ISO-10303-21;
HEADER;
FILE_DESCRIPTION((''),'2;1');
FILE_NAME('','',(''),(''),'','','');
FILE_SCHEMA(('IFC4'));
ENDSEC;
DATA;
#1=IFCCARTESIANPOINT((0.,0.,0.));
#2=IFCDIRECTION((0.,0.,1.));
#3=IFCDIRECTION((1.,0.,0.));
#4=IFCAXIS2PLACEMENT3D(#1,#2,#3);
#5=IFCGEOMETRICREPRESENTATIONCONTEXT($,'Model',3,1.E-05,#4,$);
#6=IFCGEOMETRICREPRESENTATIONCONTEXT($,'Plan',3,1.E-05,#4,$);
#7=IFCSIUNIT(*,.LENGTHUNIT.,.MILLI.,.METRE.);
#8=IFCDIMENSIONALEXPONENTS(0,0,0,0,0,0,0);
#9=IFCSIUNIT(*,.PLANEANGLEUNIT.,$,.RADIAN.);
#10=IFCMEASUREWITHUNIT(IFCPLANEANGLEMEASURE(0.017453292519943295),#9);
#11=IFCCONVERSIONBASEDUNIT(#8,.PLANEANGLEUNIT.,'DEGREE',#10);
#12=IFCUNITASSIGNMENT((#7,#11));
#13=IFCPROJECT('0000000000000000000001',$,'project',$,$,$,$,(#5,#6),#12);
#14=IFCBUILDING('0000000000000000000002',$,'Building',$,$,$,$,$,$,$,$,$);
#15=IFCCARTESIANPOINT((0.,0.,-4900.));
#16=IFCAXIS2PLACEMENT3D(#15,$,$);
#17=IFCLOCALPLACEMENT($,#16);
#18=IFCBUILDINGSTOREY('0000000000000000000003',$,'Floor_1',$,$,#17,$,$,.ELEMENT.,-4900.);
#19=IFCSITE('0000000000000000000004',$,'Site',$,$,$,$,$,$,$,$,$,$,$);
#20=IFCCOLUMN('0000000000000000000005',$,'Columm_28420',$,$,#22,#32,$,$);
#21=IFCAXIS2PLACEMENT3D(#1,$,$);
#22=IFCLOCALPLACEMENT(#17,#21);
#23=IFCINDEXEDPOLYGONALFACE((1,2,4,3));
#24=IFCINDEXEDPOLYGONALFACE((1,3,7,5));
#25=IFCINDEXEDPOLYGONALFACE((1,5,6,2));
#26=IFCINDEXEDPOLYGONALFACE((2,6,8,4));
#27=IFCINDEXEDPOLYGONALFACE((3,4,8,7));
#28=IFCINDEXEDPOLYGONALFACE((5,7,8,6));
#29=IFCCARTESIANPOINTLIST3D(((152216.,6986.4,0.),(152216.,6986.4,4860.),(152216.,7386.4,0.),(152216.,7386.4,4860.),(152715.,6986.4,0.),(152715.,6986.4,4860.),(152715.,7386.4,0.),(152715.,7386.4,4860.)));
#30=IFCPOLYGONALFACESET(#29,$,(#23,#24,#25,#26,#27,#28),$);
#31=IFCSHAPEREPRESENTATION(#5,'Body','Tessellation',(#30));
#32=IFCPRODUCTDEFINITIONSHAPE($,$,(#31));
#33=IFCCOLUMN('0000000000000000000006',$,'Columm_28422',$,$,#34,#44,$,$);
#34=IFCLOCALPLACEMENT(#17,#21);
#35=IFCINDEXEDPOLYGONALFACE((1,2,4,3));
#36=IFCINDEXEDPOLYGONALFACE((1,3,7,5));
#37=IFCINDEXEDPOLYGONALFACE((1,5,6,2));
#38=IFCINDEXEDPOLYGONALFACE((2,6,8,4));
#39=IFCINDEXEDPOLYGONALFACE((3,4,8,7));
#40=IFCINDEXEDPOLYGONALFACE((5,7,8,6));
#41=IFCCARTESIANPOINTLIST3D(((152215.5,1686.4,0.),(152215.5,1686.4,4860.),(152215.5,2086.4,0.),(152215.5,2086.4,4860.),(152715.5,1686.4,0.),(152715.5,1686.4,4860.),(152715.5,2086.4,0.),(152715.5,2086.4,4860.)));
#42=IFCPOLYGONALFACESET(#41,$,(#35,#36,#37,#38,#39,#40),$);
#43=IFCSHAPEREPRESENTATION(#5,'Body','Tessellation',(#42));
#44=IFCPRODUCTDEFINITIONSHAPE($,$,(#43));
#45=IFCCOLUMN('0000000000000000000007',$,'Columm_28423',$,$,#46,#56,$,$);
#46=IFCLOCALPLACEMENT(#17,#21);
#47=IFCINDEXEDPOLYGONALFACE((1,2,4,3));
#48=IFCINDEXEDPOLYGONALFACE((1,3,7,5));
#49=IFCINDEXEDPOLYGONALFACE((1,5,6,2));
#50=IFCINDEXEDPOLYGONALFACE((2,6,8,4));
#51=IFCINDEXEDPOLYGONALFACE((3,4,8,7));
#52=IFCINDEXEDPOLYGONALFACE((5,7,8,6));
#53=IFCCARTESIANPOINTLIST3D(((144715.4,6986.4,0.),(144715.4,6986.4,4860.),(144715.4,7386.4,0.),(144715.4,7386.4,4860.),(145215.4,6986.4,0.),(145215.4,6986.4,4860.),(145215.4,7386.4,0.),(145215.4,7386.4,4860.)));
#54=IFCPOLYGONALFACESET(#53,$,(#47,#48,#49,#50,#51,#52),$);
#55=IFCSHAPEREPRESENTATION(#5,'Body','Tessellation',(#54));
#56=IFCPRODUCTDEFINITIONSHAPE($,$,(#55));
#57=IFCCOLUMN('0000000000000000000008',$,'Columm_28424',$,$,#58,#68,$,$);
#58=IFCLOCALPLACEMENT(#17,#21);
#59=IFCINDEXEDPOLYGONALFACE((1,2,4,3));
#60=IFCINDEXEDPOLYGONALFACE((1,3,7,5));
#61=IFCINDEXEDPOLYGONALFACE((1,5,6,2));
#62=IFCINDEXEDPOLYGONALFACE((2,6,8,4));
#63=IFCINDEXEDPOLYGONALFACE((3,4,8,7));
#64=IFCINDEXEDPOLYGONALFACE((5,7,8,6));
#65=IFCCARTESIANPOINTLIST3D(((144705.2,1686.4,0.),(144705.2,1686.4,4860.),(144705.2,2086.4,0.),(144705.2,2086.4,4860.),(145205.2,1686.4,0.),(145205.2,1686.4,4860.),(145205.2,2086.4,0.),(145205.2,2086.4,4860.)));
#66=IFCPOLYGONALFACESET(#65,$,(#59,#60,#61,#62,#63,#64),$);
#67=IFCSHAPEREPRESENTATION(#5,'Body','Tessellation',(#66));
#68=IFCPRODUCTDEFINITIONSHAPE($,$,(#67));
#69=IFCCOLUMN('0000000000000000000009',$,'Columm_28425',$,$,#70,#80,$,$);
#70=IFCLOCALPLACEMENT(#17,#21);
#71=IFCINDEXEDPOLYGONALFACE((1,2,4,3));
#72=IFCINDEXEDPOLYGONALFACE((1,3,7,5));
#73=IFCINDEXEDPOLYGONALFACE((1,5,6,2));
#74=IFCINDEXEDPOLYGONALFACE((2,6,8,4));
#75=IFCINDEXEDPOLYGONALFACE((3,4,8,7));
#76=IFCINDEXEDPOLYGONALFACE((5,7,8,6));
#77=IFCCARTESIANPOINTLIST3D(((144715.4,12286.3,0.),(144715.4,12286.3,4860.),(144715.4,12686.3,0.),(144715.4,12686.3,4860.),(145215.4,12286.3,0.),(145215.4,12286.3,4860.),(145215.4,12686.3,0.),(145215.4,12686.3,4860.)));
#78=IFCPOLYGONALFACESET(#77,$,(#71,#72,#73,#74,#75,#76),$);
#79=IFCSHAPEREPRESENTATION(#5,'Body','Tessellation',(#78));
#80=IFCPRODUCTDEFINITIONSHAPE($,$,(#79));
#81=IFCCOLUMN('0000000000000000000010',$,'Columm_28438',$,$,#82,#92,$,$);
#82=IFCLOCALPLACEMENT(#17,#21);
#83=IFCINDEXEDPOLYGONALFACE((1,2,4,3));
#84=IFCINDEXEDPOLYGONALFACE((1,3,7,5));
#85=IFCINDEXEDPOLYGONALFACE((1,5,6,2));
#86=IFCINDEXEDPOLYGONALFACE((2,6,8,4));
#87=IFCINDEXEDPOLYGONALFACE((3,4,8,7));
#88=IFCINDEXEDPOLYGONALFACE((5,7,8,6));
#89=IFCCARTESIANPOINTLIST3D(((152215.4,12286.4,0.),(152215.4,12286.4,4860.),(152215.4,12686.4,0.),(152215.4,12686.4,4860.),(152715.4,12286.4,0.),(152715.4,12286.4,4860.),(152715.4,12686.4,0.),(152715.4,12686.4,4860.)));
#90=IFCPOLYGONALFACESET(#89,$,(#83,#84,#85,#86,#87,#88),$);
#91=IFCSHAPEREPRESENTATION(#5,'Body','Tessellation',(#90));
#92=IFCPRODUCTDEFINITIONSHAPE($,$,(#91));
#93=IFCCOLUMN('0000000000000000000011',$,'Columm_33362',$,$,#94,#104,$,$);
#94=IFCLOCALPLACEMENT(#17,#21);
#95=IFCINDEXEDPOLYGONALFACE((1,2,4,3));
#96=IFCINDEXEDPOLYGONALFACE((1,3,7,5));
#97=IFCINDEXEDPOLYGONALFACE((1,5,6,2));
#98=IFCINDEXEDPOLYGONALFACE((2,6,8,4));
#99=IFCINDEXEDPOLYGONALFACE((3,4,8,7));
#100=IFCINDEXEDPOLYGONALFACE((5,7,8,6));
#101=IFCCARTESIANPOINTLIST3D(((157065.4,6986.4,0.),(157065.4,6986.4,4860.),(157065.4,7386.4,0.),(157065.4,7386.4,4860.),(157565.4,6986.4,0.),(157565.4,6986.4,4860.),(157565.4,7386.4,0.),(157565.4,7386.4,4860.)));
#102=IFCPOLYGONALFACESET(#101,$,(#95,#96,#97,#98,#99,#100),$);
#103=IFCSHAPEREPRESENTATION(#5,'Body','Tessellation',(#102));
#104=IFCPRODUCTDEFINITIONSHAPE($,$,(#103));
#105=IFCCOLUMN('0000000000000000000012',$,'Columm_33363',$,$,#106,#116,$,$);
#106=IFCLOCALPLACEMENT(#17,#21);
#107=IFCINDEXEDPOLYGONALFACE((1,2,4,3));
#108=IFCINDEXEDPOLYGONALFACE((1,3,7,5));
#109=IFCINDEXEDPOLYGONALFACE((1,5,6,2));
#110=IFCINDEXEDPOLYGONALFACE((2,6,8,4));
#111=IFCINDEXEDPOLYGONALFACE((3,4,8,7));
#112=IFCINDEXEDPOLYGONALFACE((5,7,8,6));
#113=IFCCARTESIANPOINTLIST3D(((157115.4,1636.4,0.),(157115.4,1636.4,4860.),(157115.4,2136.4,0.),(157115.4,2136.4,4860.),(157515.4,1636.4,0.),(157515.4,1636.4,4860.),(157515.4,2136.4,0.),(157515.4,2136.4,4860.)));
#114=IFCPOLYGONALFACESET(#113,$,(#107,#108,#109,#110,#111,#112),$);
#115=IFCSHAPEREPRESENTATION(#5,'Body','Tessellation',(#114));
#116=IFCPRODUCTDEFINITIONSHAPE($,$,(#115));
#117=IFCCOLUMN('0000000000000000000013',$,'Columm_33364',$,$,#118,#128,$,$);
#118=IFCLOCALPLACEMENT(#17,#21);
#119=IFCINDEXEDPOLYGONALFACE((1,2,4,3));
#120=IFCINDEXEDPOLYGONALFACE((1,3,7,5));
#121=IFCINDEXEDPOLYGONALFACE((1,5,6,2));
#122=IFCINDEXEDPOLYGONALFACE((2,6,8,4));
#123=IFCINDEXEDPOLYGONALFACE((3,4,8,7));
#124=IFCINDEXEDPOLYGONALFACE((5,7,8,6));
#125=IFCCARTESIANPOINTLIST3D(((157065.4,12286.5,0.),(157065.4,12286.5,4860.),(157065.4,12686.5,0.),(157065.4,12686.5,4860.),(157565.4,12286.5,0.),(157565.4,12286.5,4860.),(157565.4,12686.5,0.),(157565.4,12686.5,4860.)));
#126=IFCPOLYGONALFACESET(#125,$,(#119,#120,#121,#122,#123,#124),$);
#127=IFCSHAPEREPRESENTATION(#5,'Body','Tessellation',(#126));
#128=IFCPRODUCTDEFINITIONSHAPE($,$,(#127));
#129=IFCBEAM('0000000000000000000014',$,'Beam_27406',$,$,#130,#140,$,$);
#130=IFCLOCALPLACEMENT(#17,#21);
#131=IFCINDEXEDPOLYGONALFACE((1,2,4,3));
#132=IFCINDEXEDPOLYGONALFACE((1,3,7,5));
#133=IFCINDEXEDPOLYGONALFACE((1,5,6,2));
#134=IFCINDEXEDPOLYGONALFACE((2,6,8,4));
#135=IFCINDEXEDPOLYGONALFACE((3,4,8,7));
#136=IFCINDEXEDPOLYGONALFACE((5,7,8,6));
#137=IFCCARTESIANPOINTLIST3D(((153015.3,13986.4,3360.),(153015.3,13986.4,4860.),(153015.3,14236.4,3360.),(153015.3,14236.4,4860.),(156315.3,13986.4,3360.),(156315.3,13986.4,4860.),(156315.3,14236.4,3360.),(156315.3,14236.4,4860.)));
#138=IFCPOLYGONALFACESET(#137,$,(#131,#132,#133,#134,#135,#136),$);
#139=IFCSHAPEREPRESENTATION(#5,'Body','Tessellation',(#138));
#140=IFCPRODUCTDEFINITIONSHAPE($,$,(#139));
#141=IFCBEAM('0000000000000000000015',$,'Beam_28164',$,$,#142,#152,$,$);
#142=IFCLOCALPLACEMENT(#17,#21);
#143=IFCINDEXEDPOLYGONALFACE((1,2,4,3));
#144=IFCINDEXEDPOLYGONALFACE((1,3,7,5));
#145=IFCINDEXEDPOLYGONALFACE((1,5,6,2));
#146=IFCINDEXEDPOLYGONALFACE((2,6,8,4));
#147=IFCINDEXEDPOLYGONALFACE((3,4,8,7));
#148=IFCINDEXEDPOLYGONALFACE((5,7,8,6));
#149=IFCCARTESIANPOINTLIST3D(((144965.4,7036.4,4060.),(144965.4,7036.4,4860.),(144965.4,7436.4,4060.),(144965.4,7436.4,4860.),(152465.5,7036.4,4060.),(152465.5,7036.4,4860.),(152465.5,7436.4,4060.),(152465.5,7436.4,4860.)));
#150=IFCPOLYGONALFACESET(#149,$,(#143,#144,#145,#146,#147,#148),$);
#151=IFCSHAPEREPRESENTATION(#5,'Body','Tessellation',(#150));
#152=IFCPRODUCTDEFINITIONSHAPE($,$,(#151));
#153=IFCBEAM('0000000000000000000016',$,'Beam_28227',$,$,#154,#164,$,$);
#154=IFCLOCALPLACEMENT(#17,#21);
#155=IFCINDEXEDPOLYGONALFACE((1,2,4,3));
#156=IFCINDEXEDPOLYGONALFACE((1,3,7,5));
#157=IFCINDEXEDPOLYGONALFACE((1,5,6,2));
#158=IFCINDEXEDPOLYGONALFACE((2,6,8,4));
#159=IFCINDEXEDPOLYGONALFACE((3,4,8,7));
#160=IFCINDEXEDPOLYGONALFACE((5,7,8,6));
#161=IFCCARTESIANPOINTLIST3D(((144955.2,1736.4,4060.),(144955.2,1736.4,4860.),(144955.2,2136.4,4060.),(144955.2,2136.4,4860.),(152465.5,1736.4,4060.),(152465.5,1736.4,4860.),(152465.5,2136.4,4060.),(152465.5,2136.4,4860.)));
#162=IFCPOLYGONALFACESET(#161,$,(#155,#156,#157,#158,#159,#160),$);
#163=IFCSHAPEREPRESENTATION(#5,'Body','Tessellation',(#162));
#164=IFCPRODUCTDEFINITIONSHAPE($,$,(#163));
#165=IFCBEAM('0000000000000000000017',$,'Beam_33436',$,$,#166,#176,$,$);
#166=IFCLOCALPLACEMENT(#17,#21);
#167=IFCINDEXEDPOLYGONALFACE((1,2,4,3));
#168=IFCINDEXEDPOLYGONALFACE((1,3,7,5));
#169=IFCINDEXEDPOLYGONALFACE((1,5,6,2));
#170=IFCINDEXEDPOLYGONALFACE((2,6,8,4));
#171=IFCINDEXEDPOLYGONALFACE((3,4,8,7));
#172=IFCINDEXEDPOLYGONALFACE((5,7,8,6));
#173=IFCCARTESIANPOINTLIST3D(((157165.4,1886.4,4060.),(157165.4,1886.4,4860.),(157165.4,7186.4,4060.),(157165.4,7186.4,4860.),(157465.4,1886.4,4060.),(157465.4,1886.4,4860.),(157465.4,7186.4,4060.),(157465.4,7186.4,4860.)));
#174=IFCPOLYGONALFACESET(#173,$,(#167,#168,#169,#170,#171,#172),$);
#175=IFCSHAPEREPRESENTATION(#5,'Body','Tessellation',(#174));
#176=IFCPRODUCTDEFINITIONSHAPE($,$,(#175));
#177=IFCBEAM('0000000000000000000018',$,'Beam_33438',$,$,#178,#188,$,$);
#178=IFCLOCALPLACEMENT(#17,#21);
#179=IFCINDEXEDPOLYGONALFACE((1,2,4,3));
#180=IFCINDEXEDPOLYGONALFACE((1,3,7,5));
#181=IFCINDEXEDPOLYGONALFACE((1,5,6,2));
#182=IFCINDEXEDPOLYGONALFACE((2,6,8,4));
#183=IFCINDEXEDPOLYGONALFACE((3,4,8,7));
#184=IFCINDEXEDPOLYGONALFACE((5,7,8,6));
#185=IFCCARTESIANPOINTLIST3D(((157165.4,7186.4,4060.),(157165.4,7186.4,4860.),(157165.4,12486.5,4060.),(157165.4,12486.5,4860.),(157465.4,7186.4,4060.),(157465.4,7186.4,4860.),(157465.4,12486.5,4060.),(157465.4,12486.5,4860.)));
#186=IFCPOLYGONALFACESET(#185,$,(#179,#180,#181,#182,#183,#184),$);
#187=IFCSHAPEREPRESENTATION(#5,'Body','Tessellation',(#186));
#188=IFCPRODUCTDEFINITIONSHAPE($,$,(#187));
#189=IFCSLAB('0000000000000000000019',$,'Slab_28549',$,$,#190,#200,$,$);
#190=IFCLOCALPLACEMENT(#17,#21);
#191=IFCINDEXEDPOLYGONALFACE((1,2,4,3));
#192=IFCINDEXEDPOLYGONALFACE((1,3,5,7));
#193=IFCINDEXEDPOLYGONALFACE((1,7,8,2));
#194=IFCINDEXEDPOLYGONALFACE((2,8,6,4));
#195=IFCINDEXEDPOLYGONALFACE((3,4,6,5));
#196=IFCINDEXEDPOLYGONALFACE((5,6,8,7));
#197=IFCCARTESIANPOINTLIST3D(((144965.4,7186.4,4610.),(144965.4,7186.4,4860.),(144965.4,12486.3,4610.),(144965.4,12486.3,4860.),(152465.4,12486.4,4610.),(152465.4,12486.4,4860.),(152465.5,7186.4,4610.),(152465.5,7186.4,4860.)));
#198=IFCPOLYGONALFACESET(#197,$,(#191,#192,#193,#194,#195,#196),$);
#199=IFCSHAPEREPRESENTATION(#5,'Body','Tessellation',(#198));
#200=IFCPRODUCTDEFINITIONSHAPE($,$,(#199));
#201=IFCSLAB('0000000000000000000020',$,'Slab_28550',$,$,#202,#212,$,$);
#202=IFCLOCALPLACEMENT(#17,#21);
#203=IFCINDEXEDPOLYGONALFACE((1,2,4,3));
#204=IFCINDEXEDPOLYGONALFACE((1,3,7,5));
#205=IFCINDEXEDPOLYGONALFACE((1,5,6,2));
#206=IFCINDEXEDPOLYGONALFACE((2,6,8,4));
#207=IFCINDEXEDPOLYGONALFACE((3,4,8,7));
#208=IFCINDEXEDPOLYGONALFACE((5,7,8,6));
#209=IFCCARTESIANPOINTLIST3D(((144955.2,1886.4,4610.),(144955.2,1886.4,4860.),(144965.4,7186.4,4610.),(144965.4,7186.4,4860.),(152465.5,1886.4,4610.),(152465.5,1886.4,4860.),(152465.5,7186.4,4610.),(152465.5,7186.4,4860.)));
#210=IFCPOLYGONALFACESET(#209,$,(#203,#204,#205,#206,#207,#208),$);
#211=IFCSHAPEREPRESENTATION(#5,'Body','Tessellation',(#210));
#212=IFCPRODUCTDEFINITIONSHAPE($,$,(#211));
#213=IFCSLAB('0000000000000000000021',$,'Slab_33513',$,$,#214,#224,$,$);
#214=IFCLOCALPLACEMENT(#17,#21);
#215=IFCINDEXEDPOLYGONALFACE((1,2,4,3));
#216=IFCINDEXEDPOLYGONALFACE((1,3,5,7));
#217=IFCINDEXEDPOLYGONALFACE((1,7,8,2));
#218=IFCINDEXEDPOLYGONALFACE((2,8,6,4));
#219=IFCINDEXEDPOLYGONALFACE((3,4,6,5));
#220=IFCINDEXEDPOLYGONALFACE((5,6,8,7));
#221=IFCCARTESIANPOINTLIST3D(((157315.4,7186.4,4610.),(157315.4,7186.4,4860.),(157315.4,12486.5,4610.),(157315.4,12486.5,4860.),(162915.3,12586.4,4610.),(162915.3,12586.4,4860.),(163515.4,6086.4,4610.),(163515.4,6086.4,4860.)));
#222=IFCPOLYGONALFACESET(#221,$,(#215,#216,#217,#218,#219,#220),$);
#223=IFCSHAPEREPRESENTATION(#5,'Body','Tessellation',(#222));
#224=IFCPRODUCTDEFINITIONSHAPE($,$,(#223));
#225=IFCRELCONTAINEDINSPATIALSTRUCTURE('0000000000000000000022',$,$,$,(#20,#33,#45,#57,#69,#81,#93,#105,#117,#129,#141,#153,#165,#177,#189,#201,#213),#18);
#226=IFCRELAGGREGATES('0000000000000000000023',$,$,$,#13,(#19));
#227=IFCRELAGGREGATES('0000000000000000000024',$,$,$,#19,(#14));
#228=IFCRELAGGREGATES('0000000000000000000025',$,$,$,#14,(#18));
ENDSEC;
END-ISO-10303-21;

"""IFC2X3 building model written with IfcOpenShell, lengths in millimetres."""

from ifc_helpers import new_model, entity, si_unit, converted_unit, frame, origin_with_axes, origin_2d, place, context, project, spatial, polyline, rectangle, outline, extrude, element, save


model = new_model("IFC2X3")

# Units and contexts
model_context = context("Model", 3, precision=1e-05, world=origin_with_axes())
plan_context = context("Plan", 3, precision=1e-05, world=origin_with_axes())
ifc_project = project(units=[si_unit("LENGTHUNIT", "METRE", prefix="MILLI"), converted_unit("PLANEANGLEUNIT", "DEGREE", entity("IfcPlaneAngleMeasure", 0.017453292519943295), si_unit("PLANEANGLEUNIT", "RADIAN"), dimensions=[0, 0, 0, 0, 0, 0, 0])], contexts=[model_context, plan_context])

# Site, building, storey
site = spatial("IfcSite", under=ifc_project, Name="Site")
building = spatial("IfcBuilding", under=site, Name="Building")
storey_placement = place(None, frame((0.0, 0.0, -4900.0)))
storey = spatial("IfcBuildingStorey", under=building, at=storey_placement, Name="Floor_1", CompositionType="ELEMENT", Elevation=-4900.0)

# Columns
column_1_placement = place(storey_placement, frame((152465.5, 7186.4, 0.0), z_axis=(0.0, 0.0, 1.0), x_axis=(1.0, 0.0, 0.0)))
element("IfcColumn", 1, at=column_1_placement, inside=storey, Name="Columm_28420", context=model_context, shape_type="SweptSolid", body=[
    extrude(rectangle(XDim=499.0, YDim=400.0, at=origin_2d()), origin_with_axes(), (0.0, 0.0, 1.0), 4860.0),
])
for number, where, z_axis, x_axis, name in (
    (2, (152465.5, 1886.4, 0.0), (0.0, 0.0, 1.0), (1.0, 0.0, 0.0), "Columm_28422"),
    (3, (144965.4, 7186.4, 0.0), (0.0, 0.0, 1.0), (1.0, 0.0, 0.0), "Columm_28423"),
    (4, (144955.2, 1886.4, 0.0), (0.0, 0.0, 1.0), (1.0, 0.0, 0.0), "Columm_28424"),
    (5, (144965.4, 12486.3, 0.0), (0.0, 0.0, 1.0), (1.0, 0.0, 0.0), "Columm_28425"),
    (6, (152465.4, 12486.4, 0.0), (0.0, 0.0, 1.0), (1.0, 0.0, 0.0), "Columm_28438"),
):
    element("IfcColumn", number, at=place(storey_placement, frame(where, z_axis=z_axis, x_axis=x_axis)), inside=storey, Name=name, context=model_context, shape_type="SweptSolid", body=[
        extrude(rectangle(XDim=500.0, YDim=400.0, at=origin_2d()), origin_with_axes(), (0.0, 0.0, 1.0), 4860.0),
    ])
column_2_placement = place(storey_placement, frame((157315.4, 7186.4, 0.0), z_axis=(0.0, 0.0, 1.0), x_axis=(1.0, 0.0, 0.0)))
element("IfcColumn", 7, at=column_2_placement, inside=storey, Name="Columm_33362", context=model_context, shape_type="SweptSolid", body=[
    extrude(rectangle(XDim=500.0, YDim=400.0, at=origin_2d()), origin_with_axes(), (0.0, 0.0, 1.0), 4860.0),
])
column_3_placement = place(storey_placement, frame((157315.4, 1886.4, 0.0), z_axis=(0.0, 0.0, 1.0), x_axis=(1.0, 0.0, 0.0)))
element("IfcColumn", 8, at=column_3_placement, inside=storey, Name="Columm_33363", context=model_context, shape_type="SweptSolid", body=[
    extrude(rectangle(XDim=400.0, YDim=500.0, at=origin_2d()), origin_with_axes(), (0.0, 0.0, 1.0), 4860.0),
])
column_4_placement = place(storey_placement, frame((157315.4, 12486.5, 0.0), z_axis=(0.0, 0.0, 1.0), x_axis=(1.0, 0.0, 0.0)))
element("IfcColumn", 9, at=column_4_placement, inside=storey, Name="Columm_33364", context=model_context, shape_type="SweptSolid", body=[
    extrude(rectangle(XDim=500.0, YDim=400.0, at=origin_2d()), origin_with_axes(), (0.0, 0.0, 1.0), 4860.0),
])

# Beams
beam_1_placement = place(storey_placement, frame((153015.3, 14111.4, 4110.0), z_axis=(3299.977218, 0.0, 0.0), x_axis=(0.0, -3299.977218, 0.0)))
element("IfcBeam", 10, at=beam_1_placement, inside=storey, Name="Beam_27406", context=model_context, shape_type="SweptSolid", body=[
    extrude(rectangle(XDim=250.0, YDim=1500.0, at=origin_2d()), origin_with_axes(), (0.0, 0.0, 1.0), 3300.0),
])
beam_2_placement = place(storey_placement, frame((144965.4, 7236.4, 4460.0), z_axis=(7500.078695, 0.0, 0.0), x_axis=(0.0, -7500.078695, 0.0)))
element("IfcBeam", 11, at=beam_2_placement, inside=storey, Name="Beam_28164", context=model_context, shape_type="SweptSolid", body=[
    extrude(rectangle(XDim=400.0, YDim=800.0, at=origin_2d()), origin_with_axes(), (0.0, 0.0, 1.0), 7500.1),
])
beam_3_placement = place(storey_placement, frame((144955.2, 1936.4, 4460.0), z_axis=(7510.291555, 0.0, 0.0), x_axis=(0.0, -7510.291555, 0.0)))
element("IfcBeam", 12, at=beam_3_placement, inside=storey, Name="Beam_28227", context=model_context, shape_type="SweptSolid", body=[
    extrude(rectangle(XDim=400.0, YDim=800.0, at=origin_2d()), origin_with_axes(), (0.0, 0.0, 1.0), 7510.3),
])
beam_4_placement = place(storey_placement, frame((157315.4, 1886.4, 4460.0), z_axis=(0.0, 5300.012227, 0.0), x_axis=(5300.012227, 0.0, 0.0)))
element("IfcBeam", 13, at=beam_4_placement, inside=storey, Name="Beam_33436", context=model_context, shape_type="SweptSolid", body=[
    extrude(rectangle(XDim=300.0, YDim=800.0, at=origin_2d()), origin_with_axes(), (0.0, 0.0, 1.0), 5300.0),
])
beam_5_placement = place(storey_placement, frame((157315.4, 7186.4, 4460.0), z_axis=(0.0, 5300.094, 0.0), x_axis=(5300.094, 0.0, 0.0)))
element("IfcBeam", 14, at=beam_5_placement, inside=storey, Name="Beam_33438", context=model_context, shape_type="SweptSolid", body=[
    extrude(rectangle(XDim=300.0, YDim=800.0, at=origin_2d()), origin_with_axes(), (0.0, 0.0, 1.0), 5300.1),
])

# Slabs
slab_1_placement = place(storey_placement, frame((144965.4, 12486.3, 4610.0), z_axis=(0.0, 0.0, 1.0), x_axis=(0.0, -5299.937, 0.0)))
element("IfcSlab", 15, at=slab_1_placement, inside=storey, Name="Slab_28549", context=model_context, shape_type="SweptSolid", body=[
    extrude(outline(polyline([(0.0, 0.0), (5299.9, 0.0), (5299.9, 7500.1), (-0.1, 7500.0)])), origin_with_axes(), (0.0, 0.0, 1.0), 250.0),
])
slab_2_placement = place(storey_placement, frame((144965.4, 7186.4, 4610.0), z_axis=(0.0, 0.0, 1.0), x_axis=(-10.213, -5300.0, 0.0)))
element("IfcSlab", 16, at=slab_2_placement, inside=storey, Name="Slab_28550", context=model_context, shape_type="SweptSolid", body=[
    extrude(outline(polyline([(0.0, 0.0), (5300.0, 0.0), (5285.5, 7510.3), (-14.5, 7500.1)])), origin_with_axes(), (0.0, 0.0, 1.0), 250.0),
])
slab_3_placement = place(storey_placement, frame((157315.4, 12486.5, 4610.0), z_axis=(0.0, 0.0, 1.0), x_axis=(0.0, -5300.094, 0.0)))
element("IfcSlab", 17, at=slab_3_placement, inside=storey, Name="Slab_33513", context=model_context, shape_type="SweptSolid", body=[
    extrude(outline(polyline([(0.0, 0.0), (5300.1, 0.0), (6400.1, 6200.0), (-99.9, 5599.9)])), origin_with_axes(), (0.0, 0.0, 1.0), 250.0),
])

save(model, "model.ifc")
